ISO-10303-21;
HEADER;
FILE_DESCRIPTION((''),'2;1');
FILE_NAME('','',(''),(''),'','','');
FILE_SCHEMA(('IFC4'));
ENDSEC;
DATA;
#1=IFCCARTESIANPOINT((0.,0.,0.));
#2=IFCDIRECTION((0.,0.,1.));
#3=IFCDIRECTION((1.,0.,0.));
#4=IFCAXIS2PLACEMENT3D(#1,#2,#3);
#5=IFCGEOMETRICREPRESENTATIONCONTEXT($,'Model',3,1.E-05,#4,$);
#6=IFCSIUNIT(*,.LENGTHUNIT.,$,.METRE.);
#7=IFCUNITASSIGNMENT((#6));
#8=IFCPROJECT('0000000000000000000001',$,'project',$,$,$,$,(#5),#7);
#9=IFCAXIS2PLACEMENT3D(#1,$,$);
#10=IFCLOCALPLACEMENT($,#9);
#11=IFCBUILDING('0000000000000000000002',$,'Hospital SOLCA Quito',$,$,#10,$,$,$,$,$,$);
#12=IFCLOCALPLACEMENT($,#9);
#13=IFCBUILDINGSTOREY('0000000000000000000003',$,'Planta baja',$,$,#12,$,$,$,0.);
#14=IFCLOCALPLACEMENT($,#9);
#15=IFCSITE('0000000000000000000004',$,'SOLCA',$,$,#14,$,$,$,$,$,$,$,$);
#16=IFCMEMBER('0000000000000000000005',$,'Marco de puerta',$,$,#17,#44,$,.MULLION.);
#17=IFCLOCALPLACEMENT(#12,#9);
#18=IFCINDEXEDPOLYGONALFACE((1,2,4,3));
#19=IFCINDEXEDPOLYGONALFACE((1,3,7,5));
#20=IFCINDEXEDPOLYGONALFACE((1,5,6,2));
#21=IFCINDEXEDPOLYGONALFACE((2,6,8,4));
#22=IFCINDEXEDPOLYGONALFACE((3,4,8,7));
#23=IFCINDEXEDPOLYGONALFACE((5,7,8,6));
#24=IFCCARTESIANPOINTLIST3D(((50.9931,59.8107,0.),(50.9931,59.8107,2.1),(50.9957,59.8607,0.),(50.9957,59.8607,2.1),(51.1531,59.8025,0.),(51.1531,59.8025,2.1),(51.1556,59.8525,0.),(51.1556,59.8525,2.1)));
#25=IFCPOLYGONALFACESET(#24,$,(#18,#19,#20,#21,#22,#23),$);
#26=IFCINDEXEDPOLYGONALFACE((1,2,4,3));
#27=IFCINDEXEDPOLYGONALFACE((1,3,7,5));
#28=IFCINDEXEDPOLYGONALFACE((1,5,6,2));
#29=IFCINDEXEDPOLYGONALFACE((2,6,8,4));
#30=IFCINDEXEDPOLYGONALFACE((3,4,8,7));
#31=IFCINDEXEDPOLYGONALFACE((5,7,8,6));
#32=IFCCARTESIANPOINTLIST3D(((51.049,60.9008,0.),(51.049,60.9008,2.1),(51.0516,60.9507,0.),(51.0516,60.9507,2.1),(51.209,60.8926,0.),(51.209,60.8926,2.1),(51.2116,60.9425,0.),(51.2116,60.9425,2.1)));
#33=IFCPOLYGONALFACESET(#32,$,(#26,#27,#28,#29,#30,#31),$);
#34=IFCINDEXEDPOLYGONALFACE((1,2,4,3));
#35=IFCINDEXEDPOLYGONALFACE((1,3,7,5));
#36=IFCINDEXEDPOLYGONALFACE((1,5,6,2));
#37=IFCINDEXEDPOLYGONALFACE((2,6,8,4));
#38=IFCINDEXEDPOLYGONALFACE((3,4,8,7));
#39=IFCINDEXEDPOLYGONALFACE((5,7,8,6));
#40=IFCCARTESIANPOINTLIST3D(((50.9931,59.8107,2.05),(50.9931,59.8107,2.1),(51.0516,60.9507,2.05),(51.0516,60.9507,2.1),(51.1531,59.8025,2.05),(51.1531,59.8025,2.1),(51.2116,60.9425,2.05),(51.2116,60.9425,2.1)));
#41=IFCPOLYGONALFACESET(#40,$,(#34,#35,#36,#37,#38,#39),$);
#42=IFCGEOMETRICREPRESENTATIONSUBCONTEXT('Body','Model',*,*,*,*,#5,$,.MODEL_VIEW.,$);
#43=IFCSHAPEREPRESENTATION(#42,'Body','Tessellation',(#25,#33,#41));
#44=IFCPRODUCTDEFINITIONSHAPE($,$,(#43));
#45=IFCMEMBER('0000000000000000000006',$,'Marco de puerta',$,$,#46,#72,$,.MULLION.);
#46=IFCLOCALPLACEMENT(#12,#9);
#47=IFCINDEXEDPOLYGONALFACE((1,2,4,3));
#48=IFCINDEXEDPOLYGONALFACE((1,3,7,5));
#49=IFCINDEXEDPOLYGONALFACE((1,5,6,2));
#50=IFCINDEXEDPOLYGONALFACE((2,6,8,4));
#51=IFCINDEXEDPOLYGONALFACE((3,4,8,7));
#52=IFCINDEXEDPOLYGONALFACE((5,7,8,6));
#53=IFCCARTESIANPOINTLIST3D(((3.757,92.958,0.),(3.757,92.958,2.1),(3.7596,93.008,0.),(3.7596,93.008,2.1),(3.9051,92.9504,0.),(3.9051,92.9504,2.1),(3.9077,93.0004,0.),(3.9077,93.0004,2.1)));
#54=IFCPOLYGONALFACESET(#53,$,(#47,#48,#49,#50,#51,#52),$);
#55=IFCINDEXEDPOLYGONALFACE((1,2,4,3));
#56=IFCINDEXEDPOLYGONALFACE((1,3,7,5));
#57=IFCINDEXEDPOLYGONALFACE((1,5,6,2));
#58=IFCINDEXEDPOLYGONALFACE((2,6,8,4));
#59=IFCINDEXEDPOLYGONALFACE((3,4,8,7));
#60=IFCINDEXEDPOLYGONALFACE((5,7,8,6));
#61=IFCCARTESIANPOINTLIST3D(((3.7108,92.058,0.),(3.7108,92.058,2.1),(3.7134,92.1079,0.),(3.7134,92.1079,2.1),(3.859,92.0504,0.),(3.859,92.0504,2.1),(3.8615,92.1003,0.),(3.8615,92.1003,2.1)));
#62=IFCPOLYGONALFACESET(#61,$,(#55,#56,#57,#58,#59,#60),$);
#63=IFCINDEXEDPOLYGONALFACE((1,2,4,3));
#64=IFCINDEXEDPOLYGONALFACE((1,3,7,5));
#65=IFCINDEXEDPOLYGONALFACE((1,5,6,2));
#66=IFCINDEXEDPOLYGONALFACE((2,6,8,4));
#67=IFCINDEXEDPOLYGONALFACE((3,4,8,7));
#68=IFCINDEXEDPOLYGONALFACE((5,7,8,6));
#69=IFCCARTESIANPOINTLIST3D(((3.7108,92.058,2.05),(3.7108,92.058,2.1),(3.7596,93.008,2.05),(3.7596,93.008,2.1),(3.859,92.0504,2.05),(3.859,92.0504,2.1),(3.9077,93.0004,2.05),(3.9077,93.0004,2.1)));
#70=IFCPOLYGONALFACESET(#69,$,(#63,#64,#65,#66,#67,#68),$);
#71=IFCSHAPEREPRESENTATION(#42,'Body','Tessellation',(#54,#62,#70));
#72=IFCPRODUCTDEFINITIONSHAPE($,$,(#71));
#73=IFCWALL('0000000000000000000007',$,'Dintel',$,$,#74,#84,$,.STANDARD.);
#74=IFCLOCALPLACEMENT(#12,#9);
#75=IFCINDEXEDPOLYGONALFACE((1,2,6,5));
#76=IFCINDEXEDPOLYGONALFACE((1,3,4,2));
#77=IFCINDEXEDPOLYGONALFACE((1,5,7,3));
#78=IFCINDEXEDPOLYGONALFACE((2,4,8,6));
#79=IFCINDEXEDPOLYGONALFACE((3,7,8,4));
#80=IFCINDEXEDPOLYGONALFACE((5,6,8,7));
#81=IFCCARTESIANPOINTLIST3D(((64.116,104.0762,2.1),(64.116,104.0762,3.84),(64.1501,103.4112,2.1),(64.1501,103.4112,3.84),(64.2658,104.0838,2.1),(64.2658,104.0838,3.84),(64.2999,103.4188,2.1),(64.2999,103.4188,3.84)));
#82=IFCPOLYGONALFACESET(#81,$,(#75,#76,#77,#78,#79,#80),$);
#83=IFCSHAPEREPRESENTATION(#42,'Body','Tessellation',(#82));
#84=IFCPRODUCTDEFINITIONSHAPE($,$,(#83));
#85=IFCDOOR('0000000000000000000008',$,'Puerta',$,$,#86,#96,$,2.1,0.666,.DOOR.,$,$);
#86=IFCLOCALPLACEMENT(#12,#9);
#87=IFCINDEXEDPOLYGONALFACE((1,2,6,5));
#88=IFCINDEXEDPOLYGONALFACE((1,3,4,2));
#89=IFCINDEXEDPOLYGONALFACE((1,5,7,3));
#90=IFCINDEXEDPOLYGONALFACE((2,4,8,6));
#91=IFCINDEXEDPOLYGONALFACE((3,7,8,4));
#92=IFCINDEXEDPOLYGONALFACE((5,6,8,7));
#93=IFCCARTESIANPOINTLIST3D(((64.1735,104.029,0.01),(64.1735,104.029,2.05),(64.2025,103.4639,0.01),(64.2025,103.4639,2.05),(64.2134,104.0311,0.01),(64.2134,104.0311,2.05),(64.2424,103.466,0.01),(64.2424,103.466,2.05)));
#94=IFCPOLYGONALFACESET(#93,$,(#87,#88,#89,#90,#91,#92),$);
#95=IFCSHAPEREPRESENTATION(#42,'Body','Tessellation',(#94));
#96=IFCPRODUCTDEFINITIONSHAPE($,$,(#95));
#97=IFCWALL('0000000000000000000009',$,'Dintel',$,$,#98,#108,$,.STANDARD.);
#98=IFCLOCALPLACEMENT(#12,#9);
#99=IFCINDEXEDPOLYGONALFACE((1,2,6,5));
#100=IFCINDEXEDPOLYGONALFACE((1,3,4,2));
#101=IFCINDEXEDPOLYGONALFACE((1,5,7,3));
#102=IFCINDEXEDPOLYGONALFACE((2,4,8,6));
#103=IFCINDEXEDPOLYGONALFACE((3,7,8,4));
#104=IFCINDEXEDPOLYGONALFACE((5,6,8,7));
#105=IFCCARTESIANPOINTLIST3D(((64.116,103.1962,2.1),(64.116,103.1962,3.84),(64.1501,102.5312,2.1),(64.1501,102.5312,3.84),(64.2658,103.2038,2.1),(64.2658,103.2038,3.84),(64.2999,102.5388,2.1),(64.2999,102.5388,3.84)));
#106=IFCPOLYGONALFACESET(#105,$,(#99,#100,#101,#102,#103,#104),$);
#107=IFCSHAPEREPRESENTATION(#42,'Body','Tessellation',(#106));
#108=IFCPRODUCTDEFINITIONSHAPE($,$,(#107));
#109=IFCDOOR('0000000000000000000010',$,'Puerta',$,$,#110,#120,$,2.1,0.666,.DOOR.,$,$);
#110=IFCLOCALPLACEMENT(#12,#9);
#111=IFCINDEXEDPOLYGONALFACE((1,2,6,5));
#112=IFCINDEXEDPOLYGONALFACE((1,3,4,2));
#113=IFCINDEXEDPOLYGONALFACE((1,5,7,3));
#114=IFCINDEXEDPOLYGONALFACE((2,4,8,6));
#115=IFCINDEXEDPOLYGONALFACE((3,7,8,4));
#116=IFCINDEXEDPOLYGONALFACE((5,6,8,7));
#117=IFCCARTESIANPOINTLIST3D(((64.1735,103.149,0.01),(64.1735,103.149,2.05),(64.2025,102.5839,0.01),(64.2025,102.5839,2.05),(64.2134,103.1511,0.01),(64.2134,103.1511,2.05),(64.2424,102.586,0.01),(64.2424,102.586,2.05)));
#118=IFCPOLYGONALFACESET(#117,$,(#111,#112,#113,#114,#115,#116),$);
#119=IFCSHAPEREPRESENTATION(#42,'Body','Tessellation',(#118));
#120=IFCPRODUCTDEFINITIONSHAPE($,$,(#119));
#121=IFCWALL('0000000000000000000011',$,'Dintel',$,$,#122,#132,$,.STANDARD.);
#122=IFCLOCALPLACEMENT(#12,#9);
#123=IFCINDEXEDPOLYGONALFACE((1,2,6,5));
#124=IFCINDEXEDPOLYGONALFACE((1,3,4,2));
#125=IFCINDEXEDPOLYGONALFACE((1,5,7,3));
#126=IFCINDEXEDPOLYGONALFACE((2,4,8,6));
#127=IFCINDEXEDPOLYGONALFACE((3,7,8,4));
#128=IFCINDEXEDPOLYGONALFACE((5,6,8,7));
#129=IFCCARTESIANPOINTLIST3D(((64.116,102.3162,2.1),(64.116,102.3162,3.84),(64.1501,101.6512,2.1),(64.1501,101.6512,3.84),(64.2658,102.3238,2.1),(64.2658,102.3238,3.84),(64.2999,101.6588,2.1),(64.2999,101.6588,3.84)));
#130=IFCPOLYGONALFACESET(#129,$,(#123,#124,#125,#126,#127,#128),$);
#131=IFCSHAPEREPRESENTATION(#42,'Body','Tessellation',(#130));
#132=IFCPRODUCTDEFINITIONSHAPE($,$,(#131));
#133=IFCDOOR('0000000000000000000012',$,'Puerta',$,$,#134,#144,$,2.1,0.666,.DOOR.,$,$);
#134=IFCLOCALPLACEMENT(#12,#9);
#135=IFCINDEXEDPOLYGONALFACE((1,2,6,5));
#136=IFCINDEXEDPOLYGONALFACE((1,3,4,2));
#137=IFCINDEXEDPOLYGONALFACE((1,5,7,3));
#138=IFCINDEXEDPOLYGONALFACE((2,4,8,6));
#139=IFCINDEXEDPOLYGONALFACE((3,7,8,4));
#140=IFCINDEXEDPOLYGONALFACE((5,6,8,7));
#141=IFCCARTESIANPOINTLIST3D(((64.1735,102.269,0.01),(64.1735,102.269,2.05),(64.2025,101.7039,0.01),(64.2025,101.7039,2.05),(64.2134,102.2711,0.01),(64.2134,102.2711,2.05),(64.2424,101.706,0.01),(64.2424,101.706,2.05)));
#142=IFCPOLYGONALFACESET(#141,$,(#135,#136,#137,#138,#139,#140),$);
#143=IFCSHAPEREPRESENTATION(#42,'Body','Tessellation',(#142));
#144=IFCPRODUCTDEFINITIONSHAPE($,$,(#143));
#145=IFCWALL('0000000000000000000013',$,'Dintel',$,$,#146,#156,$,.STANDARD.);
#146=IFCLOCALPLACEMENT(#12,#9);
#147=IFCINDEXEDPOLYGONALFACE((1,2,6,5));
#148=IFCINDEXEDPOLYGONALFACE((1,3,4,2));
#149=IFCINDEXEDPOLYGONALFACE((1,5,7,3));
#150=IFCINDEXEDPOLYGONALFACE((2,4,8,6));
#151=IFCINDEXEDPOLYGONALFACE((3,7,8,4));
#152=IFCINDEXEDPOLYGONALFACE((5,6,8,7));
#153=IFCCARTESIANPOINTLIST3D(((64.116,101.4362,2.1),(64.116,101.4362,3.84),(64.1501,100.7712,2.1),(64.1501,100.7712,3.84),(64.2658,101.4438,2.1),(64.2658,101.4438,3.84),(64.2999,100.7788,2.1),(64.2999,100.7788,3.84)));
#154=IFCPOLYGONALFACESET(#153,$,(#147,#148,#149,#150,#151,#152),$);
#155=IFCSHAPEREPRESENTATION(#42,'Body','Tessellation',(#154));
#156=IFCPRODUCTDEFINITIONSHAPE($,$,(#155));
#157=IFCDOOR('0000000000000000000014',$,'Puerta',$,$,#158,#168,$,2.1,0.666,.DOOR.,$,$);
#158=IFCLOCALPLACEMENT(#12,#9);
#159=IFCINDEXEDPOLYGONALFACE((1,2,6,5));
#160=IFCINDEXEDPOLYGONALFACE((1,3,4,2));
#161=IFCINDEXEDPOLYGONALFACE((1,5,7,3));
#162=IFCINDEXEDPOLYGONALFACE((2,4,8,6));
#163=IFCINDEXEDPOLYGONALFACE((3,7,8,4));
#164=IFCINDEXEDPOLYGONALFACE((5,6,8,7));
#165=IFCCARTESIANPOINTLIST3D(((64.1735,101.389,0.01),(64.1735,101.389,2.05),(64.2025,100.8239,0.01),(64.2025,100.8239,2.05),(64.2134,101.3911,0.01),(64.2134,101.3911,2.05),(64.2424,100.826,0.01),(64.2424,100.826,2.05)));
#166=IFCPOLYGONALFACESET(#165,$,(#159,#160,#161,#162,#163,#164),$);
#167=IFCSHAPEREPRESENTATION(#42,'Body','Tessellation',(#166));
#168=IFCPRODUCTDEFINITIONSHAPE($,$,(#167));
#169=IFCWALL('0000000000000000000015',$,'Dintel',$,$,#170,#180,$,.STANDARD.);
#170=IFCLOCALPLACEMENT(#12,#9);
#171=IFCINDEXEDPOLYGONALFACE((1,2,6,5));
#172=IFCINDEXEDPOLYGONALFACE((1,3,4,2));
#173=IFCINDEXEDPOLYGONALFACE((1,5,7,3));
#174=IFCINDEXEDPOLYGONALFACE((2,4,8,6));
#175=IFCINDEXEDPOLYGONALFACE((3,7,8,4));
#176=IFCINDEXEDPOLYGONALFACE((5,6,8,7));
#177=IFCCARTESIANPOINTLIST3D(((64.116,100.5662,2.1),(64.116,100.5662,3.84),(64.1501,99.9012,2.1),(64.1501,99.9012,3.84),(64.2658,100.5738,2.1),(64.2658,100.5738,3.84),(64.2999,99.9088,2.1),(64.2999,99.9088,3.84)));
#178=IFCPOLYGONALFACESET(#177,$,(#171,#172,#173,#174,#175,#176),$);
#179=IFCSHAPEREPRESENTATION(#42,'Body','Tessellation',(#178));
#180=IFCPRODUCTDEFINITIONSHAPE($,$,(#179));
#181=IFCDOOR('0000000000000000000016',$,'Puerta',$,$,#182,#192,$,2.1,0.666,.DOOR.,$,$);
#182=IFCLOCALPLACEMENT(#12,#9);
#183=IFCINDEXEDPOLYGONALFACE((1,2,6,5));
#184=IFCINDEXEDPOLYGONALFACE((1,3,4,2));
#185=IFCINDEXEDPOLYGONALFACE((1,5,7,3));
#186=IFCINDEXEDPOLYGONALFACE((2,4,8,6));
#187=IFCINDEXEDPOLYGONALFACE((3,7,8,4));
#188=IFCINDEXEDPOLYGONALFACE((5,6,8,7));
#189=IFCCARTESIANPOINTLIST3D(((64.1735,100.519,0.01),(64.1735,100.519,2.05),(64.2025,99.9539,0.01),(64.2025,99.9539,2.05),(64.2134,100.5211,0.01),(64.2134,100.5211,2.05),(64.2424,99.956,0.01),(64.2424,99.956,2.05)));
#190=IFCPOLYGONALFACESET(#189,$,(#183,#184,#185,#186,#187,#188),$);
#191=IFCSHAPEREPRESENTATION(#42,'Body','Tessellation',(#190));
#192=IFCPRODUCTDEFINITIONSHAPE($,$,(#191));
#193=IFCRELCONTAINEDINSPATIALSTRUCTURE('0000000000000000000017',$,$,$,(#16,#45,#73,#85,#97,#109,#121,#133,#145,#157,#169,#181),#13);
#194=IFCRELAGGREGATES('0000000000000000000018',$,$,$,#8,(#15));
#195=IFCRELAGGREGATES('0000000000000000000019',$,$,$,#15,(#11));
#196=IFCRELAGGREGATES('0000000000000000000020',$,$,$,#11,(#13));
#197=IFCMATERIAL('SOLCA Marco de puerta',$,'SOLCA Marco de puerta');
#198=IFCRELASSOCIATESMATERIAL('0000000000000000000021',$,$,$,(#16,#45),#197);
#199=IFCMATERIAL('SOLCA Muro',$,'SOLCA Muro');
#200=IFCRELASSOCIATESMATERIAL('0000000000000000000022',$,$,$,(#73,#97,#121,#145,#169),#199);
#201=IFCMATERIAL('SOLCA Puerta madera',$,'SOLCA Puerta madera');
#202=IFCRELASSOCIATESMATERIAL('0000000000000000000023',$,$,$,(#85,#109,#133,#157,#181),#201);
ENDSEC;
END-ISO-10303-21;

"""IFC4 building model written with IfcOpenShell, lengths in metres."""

from ifc_helpers import new_model, si_unit, frame, origin, origin_with_axes, place, context, subcontext, project, spatial, polyline, outline, extrude, material, element, save


model = new_model("IFC4")

# Units and contexts
model_context = context("Model", 3, precision=1e-05, world=origin_with_axes())
body_context = subcontext(model_context, "Body", "Model", "MODEL_VIEW")
ifc_project = project(units=[si_unit("LENGTHUNIT", "METRE")], contexts=[model_context])

# Site, building, storey
site_placement = place(None, origin())
site = spatial("IfcSite", under=ifc_project, at=site_placement, Name="SOLCA")
building_placement = place(None, origin())
building = spatial("IfcBuilding", under=site, at=building_placement, Name="Hospital SOLCA Quito")
storey_placement = place(None, origin())
storey = spatial("IfcBuildingStorey", under=building, at=storey_placement, Name="Planta baja", Elevation=0.0)

# Members
ifc_material_1 = material(Name="SOLCA Marco de puerta", Category="SOLCA Marco de puerta")
member_1_placement = place(storey_placement, origin_with_axes())
element("IfcMember", 1, at=member_1_placement, inside=storey, material=ifc_material_1, Name="Marco de puerta", PredefinedType="MULLION", context=body_context, shape_type="SweptSolid", body=[
    extrude(outline(polyline([(51.1531, 59.8025), (51.1556, 59.8525), (50.9957, 59.8607), (50.9931, 59.8107), (51.1531, 59.8025)])), origin_with_axes(), (0.0, 0.0, 1.0), 2.1),
    extrude(outline(polyline([(51.209, 60.8926), (51.2116, 60.9425), (51.0516, 60.9507), (51.049, 60.9008), (51.209, 60.8926)])), origin_with_axes(), (0.0, 0.0, 1.0), 2.1),
    extrude(outline(polyline([(51.1531, 59.8025), (51.2116, 60.9425), (51.0516, 60.9507), (50.9931, 59.8107), (51.1531, 59.8025)])), frame((0.0, 0.0, 2.05), z_axis=(0.0, 0.0, 1.0), x_axis=(1.0, 0.0, 0.0)), (0.0, 0.0, 1.0), 0.05),
])
member_2_placement = place(storey_placement, origin_with_axes())
element("IfcMember", 2, at=member_2_placement, inside=storey, material=ifc_material_1, Name="Marco de puerta", PredefinedType="MULLION", context=body_context, shape_type="SweptSolid", body=[
    extrude(outline(polyline([(3.7596, 93.008), (3.757, 92.958), (3.9051, 92.9504), (3.9077, 93.0004), (3.7596, 93.008)])), origin_with_axes(), (0.0, 0.0, 1.0), 2.1),
    extrude(outline(polyline([(3.7134, 92.1079), (3.7108, 92.058), (3.859, 92.0504), (3.8615, 92.1003), (3.7134, 92.1079)])), origin_with_axes(), (0.0, 0.0, 1.0), 2.1),
    extrude(outline(polyline([(3.7596, 93.008), (3.7108, 92.058), (3.859, 92.0504), (3.9077, 93.0004), (3.7596, 93.008)])), frame((0.0, 0.0, 2.05), z_axis=(0.0, 0.0, 1.0), x_axis=(1.0, 0.0, 0.0)), (0.0, 0.0, 1.0), 0.05),
])

# Wall
ifc_material_2 = material(Name="SOLCA Muro", Category="SOLCA Muro")
wall_1_placement = place(storey_placement, origin_with_axes())
element("IfcWall", 3, at=wall_1_placement, inside=storey, material=ifc_material_2, Name="Dintel", PredefinedType="STANDARD", context=body_context, shape_type="SweptSolid", body=[
    extrude(outline(polyline([(64.2999, 103.4188), (64.2658, 104.0838), (64.116, 104.0762), (64.1501, 103.4112), (64.2999, 103.4188)])), frame((0.0, 0.0, 2.1), z_axis=(0.0, 0.0, 1.0), x_axis=(1.0, 0.0, 0.0)), (0.0, 0.0, 1.0), 1.74),
])

# Door
ifc_material_3 = material(Name="SOLCA Puerta madera", Category="SOLCA Puerta madera")
door_1_placement = place(storey_placement, origin_with_axes())
element("IfcDoor", 4, at=door_1_placement, inside=storey, material=ifc_material_3, Name="Puerta", OverallHeight=2.1, OverallWidth=0.666, PredefinedType="DOOR", context=body_context, shape_type="SweptSolid", body=[
    extrude(outline(polyline([(64.2424, 103.466), (64.2134, 104.0311), (64.1735, 104.029), (64.2025, 103.4639), (64.2424, 103.466)])), frame((0.0, 0.0, 0.01), z_axis=(0.0, 0.0, 1.0), x_axis=(1.0, 0.0, 0.0)), (0.0, 0.0, 1.0), 2.04),
])

# Wall
wall_2_placement = place(storey_placement, origin_with_axes())
element("IfcWall", 5, at=wall_2_placement, inside=storey, material=ifc_material_2, Name="Dintel", PredefinedType="STANDARD", context=body_context, shape_type="SweptSolid", body=[
    extrude(outline(polyline([(64.2999, 102.5388), (64.2658, 103.2038), (64.116, 103.1962), (64.1501, 102.5312), (64.2999, 102.5388)])), frame((0.0, 0.0, 2.1), z_axis=(0.0, 0.0, 1.0), x_axis=(1.0, 0.0, 0.0)), (0.0, 0.0, 1.0), 1.74),
])

# Door
door_2_placement = place(storey_placement, origin_with_axes())
element("IfcDoor", 6, at=door_2_placement, inside=storey, material=ifc_material_3, Name="Puerta", OverallHeight=2.1, OverallWidth=0.666, PredefinedType="DOOR", context=body_context, shape_type="SweptSolid", body=[
    extrude(outline(polyline([(64.2424, 102.586), (64.2134, 103.1511), (64.1735, 103.149), (64.2025, 102.5839), (64.2424, 102.586)])), frame((0.0, 0.0, 0.01), z_axis=(0.0, 0.0, 1.0), x_axis=(1.0, 0.0, 0.0)), (0.0, 0.0, 1.0), 2.04),
])

# Wall
wall_3_placement = place(storey_placement, origin_with_axes())
element("IfcWall", 7, at=wall_3_placement, inside=storey, material=ifc_material_2, Name="Dintel", PredefinedType="STANDARD", context=body_context, shape_type="SweptSolid", body=[
    extrude(outline(polyline([(64.2999, 101.6588), (64.2658, 102.3238), (64.116, 102.3162), (64.1501, 101.6512), (64.2999, 101.6588)])), frame((0.0, 0.0, 2.1), z_axis=(0.0, 0.0, 1.0), x_axis=(1.0, 0.0, 0.0)), (0.0, 0.0, 1.0), 1.74),
])

# Door
door_3_placement = place(storey_placement, origin_with_axes())
element("IfcDoor", 8, at=door_3_placement, inside=storey, material=ifc_material_3, Name="Puerta", OverallHeight=2.1, OverallWidth=0.666, PredefinedType="DOOR", context=body_context, shape_type="SweptSolid", body=[
    extrude(outline(polyline([(64.2424, 101.706), (64.2134, 102.2711), (64.1735, 102.269), (64.2025, 101.7039), (64.2424, 101.706)])), frame((0.0, 0.0, 0.01), z_axis=(0.0, 0.0, 1.0), x_axis=(1.0, 0.0, 0.0)), (0.0, 0.0, 1.0), 2.04),
])

# Wall
wall_4_placement = place(storey_placement, origin_with_axes())
element("IfcWall", 9, at=wall_4_placement, inside=storey, material=ifc_material_2, Name="Dintel", PredefinedType="STANDARD", context=body_context, shape_type="SweptSolid", body=[
    extrude(outline(polyline([(64.2999, 100.7788), (64.2658, 101.4438), (64.116, 101.4362), (64.1501, 100.7712), (64.2999, 100.7788)])), frame((0.0, 0.0, 2.1), z_axis=(0.0, 0.0, 1.0), x_axis=(1.0, 0.0, 0.0)), (0.0, 0.0, 1.0), 1.74),
])

# Door
door_4_placement = place(storey_placement, origin_with_axes())
element("IfcDoor", 10, at=door_4_placement, inside=storey, material=ifc_material_3, Name="Puerta", OverallHeight=2.1, OverallWidth=0.666, PredefinedType="DOOR", context=body_context, shape_type="SweptSolid", body=[
    extrude(outline(polyline([(64.2424, 100.826), (64.2134, 101.3911), (64.1735, 101.389), (64.2025, 100.8239), (64.2424, 100.826)])), frame((0.0, 0.0, 0.01), z_axis=(0.0, 0.0, 1.0), x_axis=(1.0, 0.0, 0.0)), (0.0, 0.0, 1.0), 2.04),
])

# Wall
wall_5_placement = place(storey_placement, origin_with_axes())
element("IfcWall", 11, at=wall_5_placement, inside=storey, material=ifc_material_2, Name="Dintel", PredefinedType="STANDARD", context=body_context, shape_type="SweptSolid", body=[
    extrude(outline(polyline([(64.2999, 99.9088), (64.2658, 100.5738), (64.116, 100.5662), (64.1501, 99.9012), (64.2999, 99.9088)])), frame((0.0, 0.0, 2.1), z_axis=(0.0, 0.0, 1.0), x_axis=(1.0, 0.0, 0.0)), (0.0, 0.0, 1.0), 1.74),
])

# Door
door_5_placement = place(storey_placement, origin_with_axes())
element("IfcDoor", 12, at=door_5_placement, inside=storey, material=ifc_material_3, Name="Puerta", OverallHeight=2.1, OverallWidth=0.666, PredefinedType="DOOR", context=body_context, shape_type="SweptSolid", body=[
    extrude(outline(polyline([(64.2424, 99.956), (64.2134, 100.5211), (64.1735, 100.519), (64.2025, 99.9539), (64.2424, 99.956)])), frame((0.0, 0.0, 0.01), z_axis=(0.0, 0.0, 1.0), x_axis=(1.0, 0.0, 0.0)), (0.0, 0.0, 1.0), 2.04),
])

save(model, "model.ifc")
